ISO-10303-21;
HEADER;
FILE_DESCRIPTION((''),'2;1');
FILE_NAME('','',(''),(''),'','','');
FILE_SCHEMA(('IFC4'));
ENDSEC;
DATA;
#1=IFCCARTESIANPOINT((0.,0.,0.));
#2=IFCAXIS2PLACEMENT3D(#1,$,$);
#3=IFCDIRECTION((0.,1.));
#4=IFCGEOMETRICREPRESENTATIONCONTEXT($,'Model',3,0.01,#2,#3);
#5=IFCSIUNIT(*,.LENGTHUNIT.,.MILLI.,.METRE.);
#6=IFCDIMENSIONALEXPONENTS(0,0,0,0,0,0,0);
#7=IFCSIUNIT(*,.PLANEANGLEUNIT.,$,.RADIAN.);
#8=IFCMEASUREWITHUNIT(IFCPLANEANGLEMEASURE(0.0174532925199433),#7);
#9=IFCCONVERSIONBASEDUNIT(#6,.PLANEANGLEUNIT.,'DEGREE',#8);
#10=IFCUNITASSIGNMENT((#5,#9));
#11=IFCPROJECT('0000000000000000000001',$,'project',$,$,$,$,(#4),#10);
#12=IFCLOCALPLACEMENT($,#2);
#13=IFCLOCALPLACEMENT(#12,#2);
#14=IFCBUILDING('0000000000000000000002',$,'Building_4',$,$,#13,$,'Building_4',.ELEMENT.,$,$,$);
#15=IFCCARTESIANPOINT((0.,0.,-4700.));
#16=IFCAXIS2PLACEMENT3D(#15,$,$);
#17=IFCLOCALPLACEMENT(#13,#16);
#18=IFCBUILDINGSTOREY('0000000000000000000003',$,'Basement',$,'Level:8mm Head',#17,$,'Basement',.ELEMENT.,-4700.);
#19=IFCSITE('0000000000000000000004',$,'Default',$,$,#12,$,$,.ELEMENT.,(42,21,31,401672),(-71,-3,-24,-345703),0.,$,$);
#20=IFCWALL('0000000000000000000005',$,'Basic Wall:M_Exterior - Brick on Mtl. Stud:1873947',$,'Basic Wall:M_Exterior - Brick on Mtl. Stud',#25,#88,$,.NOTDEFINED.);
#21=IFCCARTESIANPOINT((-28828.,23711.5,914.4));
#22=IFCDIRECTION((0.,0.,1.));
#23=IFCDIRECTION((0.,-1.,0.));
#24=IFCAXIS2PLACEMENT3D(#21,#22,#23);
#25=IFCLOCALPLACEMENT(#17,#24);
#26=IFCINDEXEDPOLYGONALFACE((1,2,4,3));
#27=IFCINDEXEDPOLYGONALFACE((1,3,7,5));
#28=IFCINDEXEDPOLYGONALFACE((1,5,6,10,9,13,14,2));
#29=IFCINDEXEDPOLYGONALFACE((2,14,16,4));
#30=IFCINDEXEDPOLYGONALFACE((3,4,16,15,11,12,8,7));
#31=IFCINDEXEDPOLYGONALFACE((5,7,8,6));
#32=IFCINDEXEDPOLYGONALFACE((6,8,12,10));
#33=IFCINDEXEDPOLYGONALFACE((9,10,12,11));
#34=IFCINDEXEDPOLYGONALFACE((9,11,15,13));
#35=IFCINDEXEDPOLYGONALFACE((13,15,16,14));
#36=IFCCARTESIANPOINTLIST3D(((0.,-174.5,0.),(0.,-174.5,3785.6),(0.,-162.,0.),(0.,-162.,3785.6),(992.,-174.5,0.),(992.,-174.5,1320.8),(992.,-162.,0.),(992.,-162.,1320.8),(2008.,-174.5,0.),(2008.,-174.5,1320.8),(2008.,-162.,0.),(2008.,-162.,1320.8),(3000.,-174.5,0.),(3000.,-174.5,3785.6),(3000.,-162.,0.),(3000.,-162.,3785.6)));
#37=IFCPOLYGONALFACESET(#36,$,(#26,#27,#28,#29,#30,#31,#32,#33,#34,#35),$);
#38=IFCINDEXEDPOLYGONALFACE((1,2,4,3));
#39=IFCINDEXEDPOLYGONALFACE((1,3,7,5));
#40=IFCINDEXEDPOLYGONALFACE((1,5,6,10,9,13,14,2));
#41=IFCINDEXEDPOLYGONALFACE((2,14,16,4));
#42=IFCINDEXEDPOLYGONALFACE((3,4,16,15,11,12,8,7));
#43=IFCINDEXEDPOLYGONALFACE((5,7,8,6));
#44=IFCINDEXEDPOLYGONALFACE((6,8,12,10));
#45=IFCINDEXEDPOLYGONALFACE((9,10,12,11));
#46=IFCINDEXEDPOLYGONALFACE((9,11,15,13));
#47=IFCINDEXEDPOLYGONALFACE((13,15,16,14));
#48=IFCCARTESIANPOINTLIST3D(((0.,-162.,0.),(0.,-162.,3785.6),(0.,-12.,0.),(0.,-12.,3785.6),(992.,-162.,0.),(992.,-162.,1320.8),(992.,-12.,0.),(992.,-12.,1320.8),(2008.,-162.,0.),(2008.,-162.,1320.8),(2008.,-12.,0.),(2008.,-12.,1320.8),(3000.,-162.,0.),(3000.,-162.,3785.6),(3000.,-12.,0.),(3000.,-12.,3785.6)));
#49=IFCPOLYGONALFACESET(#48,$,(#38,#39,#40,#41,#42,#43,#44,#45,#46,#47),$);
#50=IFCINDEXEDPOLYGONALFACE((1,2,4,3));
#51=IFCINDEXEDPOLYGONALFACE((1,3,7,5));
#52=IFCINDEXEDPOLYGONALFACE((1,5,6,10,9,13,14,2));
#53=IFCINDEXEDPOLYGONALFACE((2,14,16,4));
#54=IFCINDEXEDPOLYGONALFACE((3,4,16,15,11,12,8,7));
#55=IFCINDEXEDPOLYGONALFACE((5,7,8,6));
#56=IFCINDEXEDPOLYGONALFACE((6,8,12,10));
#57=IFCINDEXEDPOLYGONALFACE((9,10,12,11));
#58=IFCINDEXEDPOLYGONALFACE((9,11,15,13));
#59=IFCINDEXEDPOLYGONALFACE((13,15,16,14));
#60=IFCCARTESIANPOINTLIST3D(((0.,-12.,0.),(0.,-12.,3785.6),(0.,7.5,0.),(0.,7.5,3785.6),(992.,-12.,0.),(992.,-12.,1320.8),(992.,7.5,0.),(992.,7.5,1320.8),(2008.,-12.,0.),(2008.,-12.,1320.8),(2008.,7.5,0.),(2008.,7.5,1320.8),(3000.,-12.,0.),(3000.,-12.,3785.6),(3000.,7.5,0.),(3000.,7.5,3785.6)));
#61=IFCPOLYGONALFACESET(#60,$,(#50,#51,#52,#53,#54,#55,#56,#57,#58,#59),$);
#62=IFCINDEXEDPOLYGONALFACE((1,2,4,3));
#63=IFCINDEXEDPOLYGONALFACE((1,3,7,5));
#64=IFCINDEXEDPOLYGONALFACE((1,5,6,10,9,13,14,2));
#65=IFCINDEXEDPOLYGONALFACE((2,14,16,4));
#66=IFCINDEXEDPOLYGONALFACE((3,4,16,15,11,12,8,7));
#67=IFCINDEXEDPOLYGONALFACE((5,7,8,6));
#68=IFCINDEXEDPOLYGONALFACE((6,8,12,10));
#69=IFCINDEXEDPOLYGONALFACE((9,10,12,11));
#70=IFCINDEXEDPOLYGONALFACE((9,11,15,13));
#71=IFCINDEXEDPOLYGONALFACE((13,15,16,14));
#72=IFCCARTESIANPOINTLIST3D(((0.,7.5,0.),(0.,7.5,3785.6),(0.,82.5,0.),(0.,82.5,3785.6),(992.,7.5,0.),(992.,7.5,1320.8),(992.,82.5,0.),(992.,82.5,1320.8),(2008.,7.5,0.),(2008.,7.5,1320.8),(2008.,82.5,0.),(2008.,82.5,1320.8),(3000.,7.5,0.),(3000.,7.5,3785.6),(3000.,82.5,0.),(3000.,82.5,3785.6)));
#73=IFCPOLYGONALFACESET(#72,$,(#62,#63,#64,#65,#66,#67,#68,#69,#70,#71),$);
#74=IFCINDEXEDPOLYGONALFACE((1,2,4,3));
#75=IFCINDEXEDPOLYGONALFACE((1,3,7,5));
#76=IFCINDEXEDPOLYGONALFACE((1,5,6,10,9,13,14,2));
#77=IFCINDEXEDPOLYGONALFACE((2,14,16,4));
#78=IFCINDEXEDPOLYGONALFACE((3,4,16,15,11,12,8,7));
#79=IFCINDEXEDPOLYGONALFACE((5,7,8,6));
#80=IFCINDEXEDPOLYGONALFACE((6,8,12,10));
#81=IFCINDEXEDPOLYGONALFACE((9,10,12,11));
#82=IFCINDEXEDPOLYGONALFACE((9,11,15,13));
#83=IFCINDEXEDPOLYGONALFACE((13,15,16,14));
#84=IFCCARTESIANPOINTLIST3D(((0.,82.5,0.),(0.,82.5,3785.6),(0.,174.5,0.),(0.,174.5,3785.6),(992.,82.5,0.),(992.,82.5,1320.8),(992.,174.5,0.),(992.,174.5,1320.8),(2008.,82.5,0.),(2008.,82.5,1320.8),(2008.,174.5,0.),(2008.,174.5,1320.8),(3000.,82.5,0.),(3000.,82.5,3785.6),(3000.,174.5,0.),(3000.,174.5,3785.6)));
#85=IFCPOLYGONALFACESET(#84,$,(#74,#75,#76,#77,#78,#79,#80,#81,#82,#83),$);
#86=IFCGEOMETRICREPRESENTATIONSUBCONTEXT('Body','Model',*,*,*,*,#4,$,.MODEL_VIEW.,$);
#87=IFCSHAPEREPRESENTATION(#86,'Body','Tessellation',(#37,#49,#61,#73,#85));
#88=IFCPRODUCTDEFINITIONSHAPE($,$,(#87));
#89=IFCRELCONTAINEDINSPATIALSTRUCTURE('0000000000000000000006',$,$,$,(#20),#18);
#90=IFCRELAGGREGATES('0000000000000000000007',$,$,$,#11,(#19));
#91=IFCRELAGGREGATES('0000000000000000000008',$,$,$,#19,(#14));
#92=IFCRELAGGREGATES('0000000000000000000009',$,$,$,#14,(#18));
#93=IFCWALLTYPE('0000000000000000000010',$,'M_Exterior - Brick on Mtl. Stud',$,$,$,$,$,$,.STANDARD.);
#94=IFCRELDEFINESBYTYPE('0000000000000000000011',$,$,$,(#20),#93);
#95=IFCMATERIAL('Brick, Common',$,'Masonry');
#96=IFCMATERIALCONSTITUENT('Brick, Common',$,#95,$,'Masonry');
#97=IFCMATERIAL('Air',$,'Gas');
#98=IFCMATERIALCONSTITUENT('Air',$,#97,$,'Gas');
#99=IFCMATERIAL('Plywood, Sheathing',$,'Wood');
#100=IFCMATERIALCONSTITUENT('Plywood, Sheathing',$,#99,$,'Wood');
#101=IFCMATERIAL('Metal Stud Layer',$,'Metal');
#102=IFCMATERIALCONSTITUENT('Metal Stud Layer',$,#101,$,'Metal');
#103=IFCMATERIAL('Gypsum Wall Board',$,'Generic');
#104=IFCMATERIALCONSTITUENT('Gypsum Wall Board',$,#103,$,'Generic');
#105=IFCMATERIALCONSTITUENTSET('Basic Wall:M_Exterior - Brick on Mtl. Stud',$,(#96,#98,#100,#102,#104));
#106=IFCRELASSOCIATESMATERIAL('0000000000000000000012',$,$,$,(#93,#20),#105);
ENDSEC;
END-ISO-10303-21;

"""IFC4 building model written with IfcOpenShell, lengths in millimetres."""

from ifc_helpers import new_model, entity, si_unit, converted_unit, direction, frame, origin, place, context, subcontext, project, spatial, indexed_curve, outline, extrude, material, constituent, constituent_set, type_object, element, save


model = new_model("IFC4")

# Units and contexts
model_context = context("Model", 3, precision=0.01, world=origin(), true_north=direction((0.0, 1.0)))
body_context = subcontext(model_context, "Body", "Model", "MODEL_VIEW")
ifc_project = project(units=[si_unit("LENGTHUNIT", "METRE", prefix="MILLI"), converted_unit("PLANEANGLEUNIT", "DEGREE", entity("IfcPlaneAngleMeasure", 0.0174532925199433), si_unit("PLANEANGLEUNIT", "RADIAN"), dimensions=[0, 0, 0, 0, 0, 0, 0])], contexts=[model_context])

# Site, building, storey
site_placement = place(None, origin())
site = spatial("IfcSite", under=ifc_project, at=site_placement, Name="Default", CompositionType="ELEMENT", RefLatitude=(42, 21, 31, 401672), RefLongitude=(-71, -3, -24, -345703), RefElevation=0.0)
building_placement = place(site_placement, origin())
building = spatial("IfcBuilding", under=site, at=building_placement, Name="Building_4", LongName="Building_4", CompositionType="ELEMENT")
storey_placement = place(building_placement, frame((0.0, 0.0, -4700.0)))
storey = spatial("IfcBuildingStorey", under=building, at=storey_placement, Name="Basement", ObjectType="Level:8mm Head", LongName="Basement", CompositionType="ELEMENT", Elevation=-4700.0)

# Shared definitions
ifc_material_1 = material(Name="Brick, Common", Category="Masonry")
ifc_constituent_1 = constituent(ifc_material_1, Name="Brick, Common", Category="Masonry")
ifc_material_2 = material(Name="Air", Category="Gas")
ifc_constituent_2 = constituent(ifc_material_2, Name="Air", Category="Gas")
ifc_material_3 = material(Name="Plywood, Sheathing", Category="Wood")
ifc_constituent_3 = constituent(ifc_material_3, Name="Plywood, Sheathing", Category="Wood")
ifc_material_4 = material(Name="Metal Stud Layer", Category="Metal")
ifc_constituent_4 = constituent(ifc_material_4, Name="Metal Stud Layer", Category="Metal")
ifc_material_5 = material(Name="Gypsum Wall Board", Category="Generic")
ifc_constituent_5 = constituent(ifc_material_5, Name="Gypsum Wall Board", Category="Generic")
ifc_constituent_set_1 = constituent_set(constituents=[ifc_constituent_1, ifc_constituent_2, ifc_constituent_3, ifc_constituent_4, ifc_constituent_5], Name="Basic Wall:M_Exterior - Brick on Mtl. Stud")
wall_type_1 = type_object("IfcWallType", Name="M_Exterior - Brick on Mtl. Stud", PredefinedType="STANDARD", material=ifc_constituent_set_1)

# Wall, opening
wall_1_placement = place(storey_placement, frame((-28828.0, 23711.5, 914.4), z_axis=(0.0, 0.0, 1.0), x_axis=(0.0, -1.0, 0.0)))
wall_1 = element("IfcWall", 1, at=wall_1_placement, inside=storey, type_object=wall_type_1, material=ifc_constituent_set_1, Name="Basic Wall:M_Exterior - Brick on Mtl. Stud:1873947", ObjectType="Basic Wall:M_Exterior - Brick on Mtl. Stud", PredefinedType="NOTDEFINED", context=body_context, shape_type="SweptSolid", body=[
    extrude(outline(indexed_curve([(-1500.0, -1276.6), (-508.0, -1276.6), (-508.0, 44.2), (508.0, 44.2), (508.0, -1276.6), (1500.0, -1276.6), (1500.0, 2509.0), (-1500.0, 2509.0), (-1500.0, -1276.6)], self_intersect=False)), frame((1500.0, -174.5, 1276.6), z_axis=(0.0, 1.0, 0.0), x_axis=(-1.0, 0.0, 0.0)), (0.0, 0.0, 1.0), 12.5),
    extrude(outline(indexed_curve([(-1276.6, -508.0), (-1276.6, -1500.0), (2509.0, -1500.0), (2509.0, 1500.0), (-1276.6, 1500.0), (-1276.6, 508.0), (44.2, 508.0), (44.2, -508.0), (-1276.6, -508.0)], self_intersect=False)), frame((1500.0, -162.0, 1276.6), z_axis=(0.0, -1.0, 0.0), x_axis=(0.0, 0.0, 1.0)), (0.0, 0.0, -1.0), 150.0),
    extrude(outline(indexed_curve([(-1276.6, -508.0), (-1276.6, -1500.0), (2509.0, -1500.0), (2509.0, 1500.0), (-1276.6, 1500.0), (-1276.6, 508.0), (44.2, 508.0), (44.2, -508.0), (-1276.6, -508.0)], self_intersect=False)), frame((1500.0, -12.0, 1276.6), z_axis=(0.0, -1.0, 0.0), x_axis=(0.0, 0.0, 1.0)), (0.0, 0.0, -1.0), 19.5),
    extrude(outline(indexed_curve([(-1276.6, -508.0), (-1276.6, -1500.0), (2509.0, -1500.0), (2509.0, 1500.0), (-1276.6, 1500.0), (-1276.6, 508.0), (44.2, 508.0), (44.2, -508.0), (-1276.6, -508.0)], self_intersect=False)), frame((1500.0, 7.5, 1276.6), z_axis=(0.0, -1.0, 0.0), x_axis=(0.0, 0.0, 1.0)), (0.0, 0.0, -1.0), 75.0),
    extrude(outline(indexed_curve([(-1276.6, -508.0), (-1276.6, -1500.0), (2509.0, -1500.0), (2509.0, 1500.0), (-1276.6, 1500.0), (-1276.6, 508.0), (44.2, 508.0), (44.2, -508.0), (-1276.6, -508.0)], self_intersect=False)), frame((1500.0, 82.5, 1276.6), z_axis=(0.0, -1.0, 0.0), x_axis=(0.0, 0.0, 1.0)), (0.0, 0.0, -1.0), 92.0),
])
opening_1_placement = place(wall_1_placement, frame((992.0, -174.5, -914.4)))
element("IfcOpeningElement", 2, at=opening_1_placement, cuts=wall_1, PredefinedType="OPENING", context=body_context, shape_type="SweptSolid", body=[
    extrude(outline(indexed_curve([(0.0, 1016.0), (0.0, 0.0), (2235.2, 0.0), (2235.2, 1016.0), (0.0, 1016.0)], self_intersect=False)), frame((0.0, 0.0, 0.0), z_axis=(0.0, 1.0, 0.0), x_axis=(0.0, 0.0, 1.0)), (0.0, 0.0, 1.0), 349.0),
])

save(model, "model.ifc")
